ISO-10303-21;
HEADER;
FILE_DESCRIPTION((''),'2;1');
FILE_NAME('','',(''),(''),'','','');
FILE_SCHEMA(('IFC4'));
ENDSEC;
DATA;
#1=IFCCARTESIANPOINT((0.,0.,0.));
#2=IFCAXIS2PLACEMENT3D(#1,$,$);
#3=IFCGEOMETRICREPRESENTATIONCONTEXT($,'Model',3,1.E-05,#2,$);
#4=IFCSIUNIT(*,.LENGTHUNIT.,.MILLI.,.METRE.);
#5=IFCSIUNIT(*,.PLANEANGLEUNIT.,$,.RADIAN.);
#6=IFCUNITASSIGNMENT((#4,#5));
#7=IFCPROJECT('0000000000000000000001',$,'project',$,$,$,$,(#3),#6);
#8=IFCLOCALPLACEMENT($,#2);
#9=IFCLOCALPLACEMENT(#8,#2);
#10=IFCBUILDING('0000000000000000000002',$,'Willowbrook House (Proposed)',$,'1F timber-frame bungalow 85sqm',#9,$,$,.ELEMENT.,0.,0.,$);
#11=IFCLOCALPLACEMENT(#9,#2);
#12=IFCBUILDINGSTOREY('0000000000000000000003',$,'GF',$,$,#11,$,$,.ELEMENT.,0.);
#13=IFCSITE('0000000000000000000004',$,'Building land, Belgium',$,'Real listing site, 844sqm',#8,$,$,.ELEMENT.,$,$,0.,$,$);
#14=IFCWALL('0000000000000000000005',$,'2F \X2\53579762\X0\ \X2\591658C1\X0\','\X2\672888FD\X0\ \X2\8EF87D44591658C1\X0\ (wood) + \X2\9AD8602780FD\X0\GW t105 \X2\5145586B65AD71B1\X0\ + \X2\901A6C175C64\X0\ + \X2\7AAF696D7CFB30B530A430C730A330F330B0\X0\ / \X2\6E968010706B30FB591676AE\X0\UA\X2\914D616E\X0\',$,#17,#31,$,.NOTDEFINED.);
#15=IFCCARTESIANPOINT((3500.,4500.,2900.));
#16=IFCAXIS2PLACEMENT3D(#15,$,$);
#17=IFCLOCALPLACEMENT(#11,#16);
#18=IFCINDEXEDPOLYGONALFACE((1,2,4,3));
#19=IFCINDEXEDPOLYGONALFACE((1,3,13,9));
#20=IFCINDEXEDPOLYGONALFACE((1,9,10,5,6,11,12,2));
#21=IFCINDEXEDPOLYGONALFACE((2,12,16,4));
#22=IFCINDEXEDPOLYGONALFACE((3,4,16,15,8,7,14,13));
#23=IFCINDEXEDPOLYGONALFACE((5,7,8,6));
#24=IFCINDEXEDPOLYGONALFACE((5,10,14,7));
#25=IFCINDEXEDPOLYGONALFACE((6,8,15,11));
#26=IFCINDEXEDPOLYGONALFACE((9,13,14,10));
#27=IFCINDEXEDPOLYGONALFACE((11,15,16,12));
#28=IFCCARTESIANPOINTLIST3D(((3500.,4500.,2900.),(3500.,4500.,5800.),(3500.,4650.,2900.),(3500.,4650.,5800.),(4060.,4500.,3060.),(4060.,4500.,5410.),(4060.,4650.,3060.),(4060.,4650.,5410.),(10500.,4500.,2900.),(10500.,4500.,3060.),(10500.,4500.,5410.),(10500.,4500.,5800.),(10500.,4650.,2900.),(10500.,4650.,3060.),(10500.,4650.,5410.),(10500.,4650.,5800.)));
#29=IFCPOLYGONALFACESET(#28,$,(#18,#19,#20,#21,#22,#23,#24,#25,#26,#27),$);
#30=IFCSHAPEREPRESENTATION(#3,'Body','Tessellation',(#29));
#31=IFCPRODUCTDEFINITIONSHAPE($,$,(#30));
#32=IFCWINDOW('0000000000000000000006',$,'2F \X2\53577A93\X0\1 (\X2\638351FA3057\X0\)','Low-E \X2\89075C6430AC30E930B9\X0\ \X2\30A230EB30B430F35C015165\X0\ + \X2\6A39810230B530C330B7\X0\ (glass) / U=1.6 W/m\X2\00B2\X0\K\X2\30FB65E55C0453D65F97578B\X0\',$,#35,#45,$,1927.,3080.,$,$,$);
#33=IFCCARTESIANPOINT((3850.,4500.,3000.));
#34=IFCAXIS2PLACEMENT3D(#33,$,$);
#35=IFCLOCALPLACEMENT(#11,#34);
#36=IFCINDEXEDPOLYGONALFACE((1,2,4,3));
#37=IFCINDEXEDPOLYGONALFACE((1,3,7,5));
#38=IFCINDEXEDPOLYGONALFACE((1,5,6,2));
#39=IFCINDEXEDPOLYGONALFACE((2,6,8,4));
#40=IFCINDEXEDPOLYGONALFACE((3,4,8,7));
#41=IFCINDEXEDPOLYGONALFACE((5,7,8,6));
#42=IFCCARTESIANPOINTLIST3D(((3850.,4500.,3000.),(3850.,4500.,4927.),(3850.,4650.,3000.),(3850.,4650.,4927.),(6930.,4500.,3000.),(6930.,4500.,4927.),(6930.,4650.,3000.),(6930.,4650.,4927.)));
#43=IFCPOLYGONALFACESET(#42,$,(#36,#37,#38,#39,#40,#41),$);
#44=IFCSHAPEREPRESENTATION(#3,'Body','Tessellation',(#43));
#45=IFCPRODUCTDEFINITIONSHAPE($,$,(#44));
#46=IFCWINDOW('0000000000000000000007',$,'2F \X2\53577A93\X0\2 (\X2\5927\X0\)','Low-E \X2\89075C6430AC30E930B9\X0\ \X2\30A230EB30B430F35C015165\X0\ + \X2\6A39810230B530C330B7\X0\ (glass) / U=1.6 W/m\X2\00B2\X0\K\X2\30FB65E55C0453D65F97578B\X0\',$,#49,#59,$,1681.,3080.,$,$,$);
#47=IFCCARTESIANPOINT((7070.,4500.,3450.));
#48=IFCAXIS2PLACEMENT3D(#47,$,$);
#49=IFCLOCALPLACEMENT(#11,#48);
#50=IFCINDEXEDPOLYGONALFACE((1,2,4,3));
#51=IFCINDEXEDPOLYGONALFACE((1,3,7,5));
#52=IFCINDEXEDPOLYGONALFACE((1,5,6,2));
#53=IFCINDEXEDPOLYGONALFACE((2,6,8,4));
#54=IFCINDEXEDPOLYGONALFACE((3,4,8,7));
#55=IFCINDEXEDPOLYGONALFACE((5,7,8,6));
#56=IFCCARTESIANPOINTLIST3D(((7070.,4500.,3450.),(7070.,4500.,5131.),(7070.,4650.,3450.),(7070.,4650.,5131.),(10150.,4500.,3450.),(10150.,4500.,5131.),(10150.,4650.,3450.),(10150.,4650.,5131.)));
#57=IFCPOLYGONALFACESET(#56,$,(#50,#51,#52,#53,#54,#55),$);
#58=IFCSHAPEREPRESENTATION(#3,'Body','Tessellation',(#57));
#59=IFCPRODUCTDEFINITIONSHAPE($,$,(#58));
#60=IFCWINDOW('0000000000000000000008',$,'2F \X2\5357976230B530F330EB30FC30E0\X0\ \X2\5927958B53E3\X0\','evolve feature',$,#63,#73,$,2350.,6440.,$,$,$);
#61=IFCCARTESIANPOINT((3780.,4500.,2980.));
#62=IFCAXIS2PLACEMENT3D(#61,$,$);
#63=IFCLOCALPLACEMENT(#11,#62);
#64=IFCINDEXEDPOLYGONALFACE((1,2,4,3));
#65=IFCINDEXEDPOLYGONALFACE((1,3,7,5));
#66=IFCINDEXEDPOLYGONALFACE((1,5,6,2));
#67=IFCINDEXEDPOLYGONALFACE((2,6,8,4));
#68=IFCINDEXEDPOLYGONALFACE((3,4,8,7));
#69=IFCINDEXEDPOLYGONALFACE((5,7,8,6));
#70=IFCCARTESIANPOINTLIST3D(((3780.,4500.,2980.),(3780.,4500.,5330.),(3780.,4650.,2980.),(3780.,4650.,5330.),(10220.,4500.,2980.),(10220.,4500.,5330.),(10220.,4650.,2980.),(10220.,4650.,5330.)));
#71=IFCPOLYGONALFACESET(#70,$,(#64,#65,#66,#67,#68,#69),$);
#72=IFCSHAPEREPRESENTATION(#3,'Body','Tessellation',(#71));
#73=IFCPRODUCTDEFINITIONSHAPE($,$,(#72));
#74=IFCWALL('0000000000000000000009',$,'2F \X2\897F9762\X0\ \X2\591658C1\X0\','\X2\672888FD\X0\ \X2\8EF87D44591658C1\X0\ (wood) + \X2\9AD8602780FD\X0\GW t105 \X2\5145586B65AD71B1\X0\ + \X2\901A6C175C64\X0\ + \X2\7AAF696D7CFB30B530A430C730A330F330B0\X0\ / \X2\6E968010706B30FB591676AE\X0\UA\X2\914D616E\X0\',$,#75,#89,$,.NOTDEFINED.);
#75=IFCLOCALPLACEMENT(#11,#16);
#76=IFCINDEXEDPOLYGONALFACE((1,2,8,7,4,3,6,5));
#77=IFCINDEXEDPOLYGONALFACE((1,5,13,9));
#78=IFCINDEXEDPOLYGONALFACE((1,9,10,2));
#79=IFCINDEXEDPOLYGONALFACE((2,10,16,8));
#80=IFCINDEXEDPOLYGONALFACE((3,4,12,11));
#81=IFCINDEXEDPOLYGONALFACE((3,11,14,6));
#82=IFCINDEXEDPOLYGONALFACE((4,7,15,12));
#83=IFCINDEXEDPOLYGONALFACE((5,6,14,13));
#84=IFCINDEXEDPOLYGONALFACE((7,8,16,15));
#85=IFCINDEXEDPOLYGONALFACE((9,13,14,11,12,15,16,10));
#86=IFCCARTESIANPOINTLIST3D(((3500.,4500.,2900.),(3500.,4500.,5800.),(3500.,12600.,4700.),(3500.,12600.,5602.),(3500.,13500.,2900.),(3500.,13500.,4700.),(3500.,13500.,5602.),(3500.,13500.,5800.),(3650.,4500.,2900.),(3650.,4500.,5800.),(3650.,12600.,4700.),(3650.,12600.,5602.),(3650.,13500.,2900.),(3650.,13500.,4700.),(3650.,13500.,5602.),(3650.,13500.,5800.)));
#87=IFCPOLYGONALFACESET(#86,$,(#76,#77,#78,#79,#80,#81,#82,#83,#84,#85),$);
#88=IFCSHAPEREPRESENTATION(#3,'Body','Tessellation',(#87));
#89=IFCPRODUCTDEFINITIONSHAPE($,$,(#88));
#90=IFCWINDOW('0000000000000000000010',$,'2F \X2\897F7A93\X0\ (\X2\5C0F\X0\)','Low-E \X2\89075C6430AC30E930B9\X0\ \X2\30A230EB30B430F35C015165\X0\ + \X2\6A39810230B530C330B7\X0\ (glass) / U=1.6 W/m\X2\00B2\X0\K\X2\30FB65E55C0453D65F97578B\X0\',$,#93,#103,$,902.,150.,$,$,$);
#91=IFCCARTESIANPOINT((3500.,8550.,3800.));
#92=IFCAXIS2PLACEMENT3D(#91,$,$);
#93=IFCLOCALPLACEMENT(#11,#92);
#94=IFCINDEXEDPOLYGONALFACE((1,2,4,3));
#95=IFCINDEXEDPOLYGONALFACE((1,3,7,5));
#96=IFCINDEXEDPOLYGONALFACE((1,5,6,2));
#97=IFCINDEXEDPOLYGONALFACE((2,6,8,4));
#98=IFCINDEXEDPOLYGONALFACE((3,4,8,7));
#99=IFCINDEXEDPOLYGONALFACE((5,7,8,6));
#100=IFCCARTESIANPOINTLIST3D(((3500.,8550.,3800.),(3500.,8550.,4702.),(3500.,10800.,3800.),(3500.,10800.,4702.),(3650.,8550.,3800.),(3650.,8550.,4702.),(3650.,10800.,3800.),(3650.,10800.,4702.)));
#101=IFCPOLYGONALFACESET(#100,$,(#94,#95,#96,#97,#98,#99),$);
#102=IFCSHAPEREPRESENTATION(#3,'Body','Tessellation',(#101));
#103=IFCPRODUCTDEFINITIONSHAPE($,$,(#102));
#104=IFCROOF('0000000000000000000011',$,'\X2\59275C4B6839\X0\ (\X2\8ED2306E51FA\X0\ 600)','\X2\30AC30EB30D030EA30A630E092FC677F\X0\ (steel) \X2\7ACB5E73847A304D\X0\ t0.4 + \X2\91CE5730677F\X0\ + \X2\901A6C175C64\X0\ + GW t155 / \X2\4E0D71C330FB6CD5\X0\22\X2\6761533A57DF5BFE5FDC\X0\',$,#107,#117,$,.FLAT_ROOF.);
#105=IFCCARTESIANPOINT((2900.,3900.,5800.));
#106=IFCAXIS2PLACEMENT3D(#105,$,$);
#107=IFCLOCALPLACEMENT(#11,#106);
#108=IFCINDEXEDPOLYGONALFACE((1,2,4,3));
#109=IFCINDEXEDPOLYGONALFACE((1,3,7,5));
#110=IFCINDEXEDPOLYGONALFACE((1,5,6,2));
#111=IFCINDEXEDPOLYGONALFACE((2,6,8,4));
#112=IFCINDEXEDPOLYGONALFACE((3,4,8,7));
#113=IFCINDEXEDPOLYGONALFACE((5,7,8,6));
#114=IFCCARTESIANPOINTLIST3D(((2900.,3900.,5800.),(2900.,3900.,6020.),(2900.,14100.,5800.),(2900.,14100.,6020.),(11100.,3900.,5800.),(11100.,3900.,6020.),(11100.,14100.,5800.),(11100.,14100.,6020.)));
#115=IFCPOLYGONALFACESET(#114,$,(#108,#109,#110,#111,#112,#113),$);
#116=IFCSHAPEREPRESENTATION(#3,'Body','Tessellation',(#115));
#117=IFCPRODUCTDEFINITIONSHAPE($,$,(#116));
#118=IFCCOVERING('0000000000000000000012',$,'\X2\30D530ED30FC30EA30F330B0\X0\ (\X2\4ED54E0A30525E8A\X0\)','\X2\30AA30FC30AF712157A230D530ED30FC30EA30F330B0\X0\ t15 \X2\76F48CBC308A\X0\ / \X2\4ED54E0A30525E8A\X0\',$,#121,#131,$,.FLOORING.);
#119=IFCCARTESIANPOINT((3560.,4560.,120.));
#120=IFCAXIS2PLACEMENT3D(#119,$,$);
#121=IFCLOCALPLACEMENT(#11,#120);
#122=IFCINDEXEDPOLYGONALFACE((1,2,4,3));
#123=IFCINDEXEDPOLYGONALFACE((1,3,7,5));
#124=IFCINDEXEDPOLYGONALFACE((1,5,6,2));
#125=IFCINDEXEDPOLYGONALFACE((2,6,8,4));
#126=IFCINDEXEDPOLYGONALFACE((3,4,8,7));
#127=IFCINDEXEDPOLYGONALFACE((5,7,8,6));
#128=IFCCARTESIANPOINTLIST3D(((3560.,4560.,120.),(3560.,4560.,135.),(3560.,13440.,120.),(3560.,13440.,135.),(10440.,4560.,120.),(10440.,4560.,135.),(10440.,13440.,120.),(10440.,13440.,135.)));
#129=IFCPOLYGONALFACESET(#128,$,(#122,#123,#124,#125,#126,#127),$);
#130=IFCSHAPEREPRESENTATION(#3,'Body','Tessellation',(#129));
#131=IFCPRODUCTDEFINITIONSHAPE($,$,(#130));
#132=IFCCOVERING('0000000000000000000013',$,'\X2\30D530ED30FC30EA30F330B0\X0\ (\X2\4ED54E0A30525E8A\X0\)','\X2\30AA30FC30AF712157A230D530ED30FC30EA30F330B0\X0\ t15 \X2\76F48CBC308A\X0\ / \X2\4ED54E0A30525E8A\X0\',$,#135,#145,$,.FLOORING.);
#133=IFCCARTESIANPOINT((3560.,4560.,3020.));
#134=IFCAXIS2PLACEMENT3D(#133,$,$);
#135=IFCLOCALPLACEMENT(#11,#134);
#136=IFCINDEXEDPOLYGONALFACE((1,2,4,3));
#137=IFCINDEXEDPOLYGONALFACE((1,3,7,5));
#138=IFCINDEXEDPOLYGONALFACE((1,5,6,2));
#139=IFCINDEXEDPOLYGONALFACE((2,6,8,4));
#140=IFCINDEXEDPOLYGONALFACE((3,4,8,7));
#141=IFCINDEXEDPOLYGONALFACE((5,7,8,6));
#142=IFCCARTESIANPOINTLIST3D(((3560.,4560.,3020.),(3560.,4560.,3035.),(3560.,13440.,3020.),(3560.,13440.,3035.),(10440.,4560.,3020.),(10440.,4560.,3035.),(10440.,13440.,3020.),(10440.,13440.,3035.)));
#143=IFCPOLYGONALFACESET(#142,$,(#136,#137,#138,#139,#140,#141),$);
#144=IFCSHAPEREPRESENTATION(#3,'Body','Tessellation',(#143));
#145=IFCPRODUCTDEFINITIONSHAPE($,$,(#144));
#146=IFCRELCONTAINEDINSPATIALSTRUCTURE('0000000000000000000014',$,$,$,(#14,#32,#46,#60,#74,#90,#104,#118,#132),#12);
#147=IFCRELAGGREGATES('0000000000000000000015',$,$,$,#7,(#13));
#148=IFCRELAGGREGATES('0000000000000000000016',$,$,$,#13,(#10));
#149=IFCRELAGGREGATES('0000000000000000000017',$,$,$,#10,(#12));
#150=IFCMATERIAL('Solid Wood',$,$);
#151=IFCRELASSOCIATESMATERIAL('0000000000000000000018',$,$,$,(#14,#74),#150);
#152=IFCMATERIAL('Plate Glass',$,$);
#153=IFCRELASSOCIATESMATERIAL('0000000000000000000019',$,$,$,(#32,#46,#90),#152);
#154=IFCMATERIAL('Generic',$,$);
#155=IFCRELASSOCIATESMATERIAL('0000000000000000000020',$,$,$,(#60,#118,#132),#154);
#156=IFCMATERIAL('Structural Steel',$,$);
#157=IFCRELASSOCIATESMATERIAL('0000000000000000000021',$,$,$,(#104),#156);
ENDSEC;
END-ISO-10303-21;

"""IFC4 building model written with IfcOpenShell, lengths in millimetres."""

from ifc_helpers import new_model, si_unit, frame, frame_2d, origin, place, context, project, spatial, rectangle, extrude, material, element, fill, save


model = new_model("IFC4")

# Units and contexts
model_context = context("Model", 3, precision=1e-05, world=origin())
ifc_project = project(units=[si_unit("LENGTHUNIT", "METRE", prefix="MILLI"), si_unit("PLANEANGLEUNIT", "RADIAN")], contexts=[model_context])

# Site, building, storey
site_placement = place(None, origin())
site = spatial("IfcSite", under=ifc_project, at=site_placement, Name="Building land, Belgium", ObjectType="Real listing site, 844sqm", CompositionType="ELEMENT", RefElevation=0.0)
building_placement = place(site_placement, origin())
building = spatial("IfcBuilding", under=site, at=building_placement, Name="Willowbrook House (Proposed)", ObjectType="1F timber-frame bungalow 85sqm", CompositionType="ELEMENT", ElevationOfRefHeight=0.0, ElevationOfTerrain=0.0)
storey_placement = place(building_placement, origin())
storey = spatial("IfcBuildingStorey", under=building, at=storey_placement, Name="GF", CompositionType="ELEMENT", Elevation=0.0)

# Shared definitions
ifc_material_1 = material(Name="Solid Wood")
ifc_material_2 = material(Name="Generic")

# Shared definitions
ifc_material_3 = material(Name="Plate Glass")

# Wall, openings, windows
wall_1_placement = place(storey_placement, frame((3500.0, 4500.0, 2900.0)))
wall_1 = element("IfcWall", 1, at=wall_1_placement, inside=storey, material=ifc_material_1, Name="2F 南面 外壁", Description="木製 軸組外壁 (wood) + 高性能GW t105 充填断熱 + 通気層 + 窯業系サイディング / 準耐火・外皮UA配慮", PredefinedType="NOTDEFINED", context=model_context, shape_type="SweptSolid", body=[
    extrude(rectangle(XDim=7000.0, YDim=150.0, at=frame_2d((3500.0, 75.0))), frame((3500.0, 4500.0, 2900.0)), (0.0, 0.0, 1.0), 2900.0),
])
opening_1_placement = place(storey_placement, frame((3850.0, 4500.0, 3000.0)))
opening_1 = element("IfcOpeningElement", 2, at=opening_1_placement, cuts=wall_1, PredefinedType="NOTDEFINED", context=model_context, shape_type="SweptSolid", body=[
    extrude(rectangle(XDim=3080.0, YDim=150.0, at=frame_2d((1540.0, 75.0))), frame((3850.0, 4500.0, 3000.0)), (0.0, 0.0, 1.0), 1927.0),
])
opening_2_placement = place(storey_placement, frame((7070.0, 4500.0, 3450.0)))
opening_2 = element("IfcOpeningElement", 3, at=opening_2_placement, cuts=wall_1, PredefinedType="NOTDEFINED", context=model_context, shape_type="SweptSolid", body=[
    extrude(rectangle(XDim=3080.0, YDim=150.0, at=frame_2d((1540.0, 75.0))), frame((7070.0, 4500.0, 3450.0)), (0.0, 0.0, 1.0), 1681.0),
])
opening_3_placement = place(storey_placement, frame((3780.0, 4500.0, 2980.0)))
opening_3 = element("IfcOpeningElement", 4, at=opening_3_placement, cuts=wall_1, PredefinedType="NOTDEFINED", context=model_context, shape_type="SweptSolid", body=[
    extrude(rectangle(XDim=6440.0, YDim=150.0, at=frame_2d((3220.0, 75.0))), frame((3780.0, 4500.0, 2980.0)), (0.0, 0.0, 1.0), 2350.0),
])
window_1_placement = place(storey_placement, frame((3850.0, 4500.0, 3000.0)))
window_1 = element("IfcWindow", 5, at=window_1_placement, inside=storey, material=ifc_material_3, Name="2F 南窓1 (掃出し)", Description="Low-E 複層ガラス アルゴン封入 + 樹脂サッシ (glass) / U=1.6 W/m²K・日射取得型", OverallHeight=1927.0, OverallWidth=3080.0, context=model_context, shape_type="SweptSolid", body=[
    extrude(rectangle(XDim=3080.0, YDim=150.0, at=frame_2d((1540.0, 75.0))), frame((3850.0, 4500.0, 3000.0)), (0.0, 0.0, 1.0), 1927.0),
])
fill(opening_1, window_1)
window_2_placement = place(storey_placement, frame((7070.0, 4500.0, 3450.0)))
window_2 = element("IfcWindow", 6, at=window_2_placement, inside=storey, material=ifc_material_3, Name="2F 南窓2 (大)", Description="Low-E 複層ガラス アルゴン封入 + 樹脂サッシ (glass) / U=1.6 W/m²K・日射取得型", OverallHeight=1681.0, OverallWidth=3080.0, context=model_context, shape_type="SweptSolid", body=[
    extrude(rectangle(XDim=3080.0, YDim=150.0, at=frame_2d((1540.0, 75.0))), frame((7070.0, 4500.0, 3450.0)), (0.0, 0.0, 1.0), 1681.0),
])
fill(opening_2, window_2)
window_3_placement = place(storey_placement, frame((3780.0, 4500.0, 2980.0)))
window_3 = element("IfcWindow", 7, at=window_3_placement, inside=storey, material=ifc_material_2, Name="2F 南面サンルーム 大開口", Description="evolve feature", OverallHeight=2350.0, OverallWidth=6440.0, context=model_context, shape_type="SweptSolid", body=[
    extrude(rectangle(XDim=6440.0, YDim=150.0, at=frame_2d((3220.0, 75.0))), frame((3780.0, 4500.0, 2980.0)), (0.0, 0.0, 1.0), 2350.0),
])
fill(opening_3, window_3)

# Wall, opening, window
wall_2_placement = place(storey_placement, frame((3500.0, 4500.0, 2900.0)))
wall_2 = element("IfcWall", 8, at=wall_2_placement, inside=storey, material=ifc_material_1, Name="2F 西面 外壁", Description="木製 軸組外壁 (wood) + 高性能GW t105 充填断熱 + 通気層 + 窯業系サイディング / 準耐火・外皮UA配慮", PredefinedType="NOTDEFINED", context=model_context, shape_type="SweptSolid", body=[
    extrude(rectangle(XDim=150.0, YDim=9000.0, at=frame_2d((75.0, 4500.0))), frame((3500.0, 4500.0, 2900.0)), (0.0, 0.0, 1.0), 2900.0),
])
opening_4_placement = place(storey_placement, frame((3500.0, 8550.0, 3800.0)))
opening_4 = element("IfcOpeningElement", 9, at=opening_4_placement, cuts=wall_2, PredefinedType="NOTDEFINED", context=model_context, shape_type="SweptSolid", body=[
    extrude(rectangle(XDim=150.0, YDim=2250.0, at=frame_2d((75.0, 1125.0))), frame((3500.0, 8550.0, 3800.0)), (0.0, 0.0, 1.0), 902.0),
])
window_4_placement = place(storey_placement, frame((3500.0, 8550.0, 3800.0)))
window_4 = element("IfcWindow", 10, at=window_4_placement, inside=storey, material=ifc_material_3, Name="2F 西窓 (小)", Description="Low-E 複層ガラス アルゴン封入 + 樹脂サッシ (glass) / U=1.6 W/m²K・日射取得型", OverallHeight=902.0, OverallWidth=150.0, context=model_context, shape_type="SweptSolid", body=[
    extrude(rectangle(XDim=150.0, YDim=2250.0, at=frame_2d((75.0, 1125.0))), frame((3500.0, 8550.0, 3800.0)), (0.0, 0.0, 1.0), 902.0),
])
fill(opening_4, window_4)

# Roof
ifc_material_4 = material(Name="Structural Steel")
roof_placement = place(storey_placement, frame((2900.0, 3900.0, 5800.0)))
element("IfcRoof", 11, at=roof_placement, inside=storey, material=ifc_material_4, Name="大屋根 (軒の出 600)", Description="ガルバリウム鋼板 (steel) 立平葺き t0.4 + 野地板 + 通気層 + GW t155 / 不燃・法22条区域対応", PredefinedType="FLAT_ROOF", context=model_context, shape_type="SweptSolid", body=[
    extrude(rectangle(XDim=8200.0, YDim=10200.0, at=frame_2d((4100.0, 5100.0))), frame((2900.0, 3900.0, 5800.0)), (0.0, 0.0, 1.0), 220.0),
])

# Coverings
covering_1_placement = place(storey_placement, frame((3560.0, 4560.0, 120.0)))
element("IfcCovering", 12, at=covering_1_placement, inside=storey, material=ifc_material_2, Name="フローリング (仕上げ床)", Description="オーク無垢フローリング t15 直貼り / 仕上げ床", PredefinedType="FLOORING", context=model_context, shape_type="SweptSolid", body=[
    extrude(rectangle(XDim=6880.0, YDim=8880.0, at=frame_2d((3440.0, 4440.0))), frame((3560.0, 4560.0, 120.0)), (0.0, 0.0, 1.0), 15.0),
])
covering_2_placement = place(storey_placement, frame((3560.0, 4560.0, 3020.0)))
element("IfcCovering", 13, at=covering_2_placement, inside=storey, material=ifc_material_2, Name="フローリング (仕上げ床)", Description="オーク無垢フローリング t15 直貼り / 仕上げ床", PredefinedType="FLOORING", context=model_context, shape_type="SweptSolid", body=[
    extrude(rectangle(XDim=6880.0, YDim=8880.0, at=frame_2d((3440.0, 4440.0))), frame((3560.0, 4560.0, 3020.0)), (0.0, 0.0, 1.0), 15.0),
])

save(model, "model.ifc")
